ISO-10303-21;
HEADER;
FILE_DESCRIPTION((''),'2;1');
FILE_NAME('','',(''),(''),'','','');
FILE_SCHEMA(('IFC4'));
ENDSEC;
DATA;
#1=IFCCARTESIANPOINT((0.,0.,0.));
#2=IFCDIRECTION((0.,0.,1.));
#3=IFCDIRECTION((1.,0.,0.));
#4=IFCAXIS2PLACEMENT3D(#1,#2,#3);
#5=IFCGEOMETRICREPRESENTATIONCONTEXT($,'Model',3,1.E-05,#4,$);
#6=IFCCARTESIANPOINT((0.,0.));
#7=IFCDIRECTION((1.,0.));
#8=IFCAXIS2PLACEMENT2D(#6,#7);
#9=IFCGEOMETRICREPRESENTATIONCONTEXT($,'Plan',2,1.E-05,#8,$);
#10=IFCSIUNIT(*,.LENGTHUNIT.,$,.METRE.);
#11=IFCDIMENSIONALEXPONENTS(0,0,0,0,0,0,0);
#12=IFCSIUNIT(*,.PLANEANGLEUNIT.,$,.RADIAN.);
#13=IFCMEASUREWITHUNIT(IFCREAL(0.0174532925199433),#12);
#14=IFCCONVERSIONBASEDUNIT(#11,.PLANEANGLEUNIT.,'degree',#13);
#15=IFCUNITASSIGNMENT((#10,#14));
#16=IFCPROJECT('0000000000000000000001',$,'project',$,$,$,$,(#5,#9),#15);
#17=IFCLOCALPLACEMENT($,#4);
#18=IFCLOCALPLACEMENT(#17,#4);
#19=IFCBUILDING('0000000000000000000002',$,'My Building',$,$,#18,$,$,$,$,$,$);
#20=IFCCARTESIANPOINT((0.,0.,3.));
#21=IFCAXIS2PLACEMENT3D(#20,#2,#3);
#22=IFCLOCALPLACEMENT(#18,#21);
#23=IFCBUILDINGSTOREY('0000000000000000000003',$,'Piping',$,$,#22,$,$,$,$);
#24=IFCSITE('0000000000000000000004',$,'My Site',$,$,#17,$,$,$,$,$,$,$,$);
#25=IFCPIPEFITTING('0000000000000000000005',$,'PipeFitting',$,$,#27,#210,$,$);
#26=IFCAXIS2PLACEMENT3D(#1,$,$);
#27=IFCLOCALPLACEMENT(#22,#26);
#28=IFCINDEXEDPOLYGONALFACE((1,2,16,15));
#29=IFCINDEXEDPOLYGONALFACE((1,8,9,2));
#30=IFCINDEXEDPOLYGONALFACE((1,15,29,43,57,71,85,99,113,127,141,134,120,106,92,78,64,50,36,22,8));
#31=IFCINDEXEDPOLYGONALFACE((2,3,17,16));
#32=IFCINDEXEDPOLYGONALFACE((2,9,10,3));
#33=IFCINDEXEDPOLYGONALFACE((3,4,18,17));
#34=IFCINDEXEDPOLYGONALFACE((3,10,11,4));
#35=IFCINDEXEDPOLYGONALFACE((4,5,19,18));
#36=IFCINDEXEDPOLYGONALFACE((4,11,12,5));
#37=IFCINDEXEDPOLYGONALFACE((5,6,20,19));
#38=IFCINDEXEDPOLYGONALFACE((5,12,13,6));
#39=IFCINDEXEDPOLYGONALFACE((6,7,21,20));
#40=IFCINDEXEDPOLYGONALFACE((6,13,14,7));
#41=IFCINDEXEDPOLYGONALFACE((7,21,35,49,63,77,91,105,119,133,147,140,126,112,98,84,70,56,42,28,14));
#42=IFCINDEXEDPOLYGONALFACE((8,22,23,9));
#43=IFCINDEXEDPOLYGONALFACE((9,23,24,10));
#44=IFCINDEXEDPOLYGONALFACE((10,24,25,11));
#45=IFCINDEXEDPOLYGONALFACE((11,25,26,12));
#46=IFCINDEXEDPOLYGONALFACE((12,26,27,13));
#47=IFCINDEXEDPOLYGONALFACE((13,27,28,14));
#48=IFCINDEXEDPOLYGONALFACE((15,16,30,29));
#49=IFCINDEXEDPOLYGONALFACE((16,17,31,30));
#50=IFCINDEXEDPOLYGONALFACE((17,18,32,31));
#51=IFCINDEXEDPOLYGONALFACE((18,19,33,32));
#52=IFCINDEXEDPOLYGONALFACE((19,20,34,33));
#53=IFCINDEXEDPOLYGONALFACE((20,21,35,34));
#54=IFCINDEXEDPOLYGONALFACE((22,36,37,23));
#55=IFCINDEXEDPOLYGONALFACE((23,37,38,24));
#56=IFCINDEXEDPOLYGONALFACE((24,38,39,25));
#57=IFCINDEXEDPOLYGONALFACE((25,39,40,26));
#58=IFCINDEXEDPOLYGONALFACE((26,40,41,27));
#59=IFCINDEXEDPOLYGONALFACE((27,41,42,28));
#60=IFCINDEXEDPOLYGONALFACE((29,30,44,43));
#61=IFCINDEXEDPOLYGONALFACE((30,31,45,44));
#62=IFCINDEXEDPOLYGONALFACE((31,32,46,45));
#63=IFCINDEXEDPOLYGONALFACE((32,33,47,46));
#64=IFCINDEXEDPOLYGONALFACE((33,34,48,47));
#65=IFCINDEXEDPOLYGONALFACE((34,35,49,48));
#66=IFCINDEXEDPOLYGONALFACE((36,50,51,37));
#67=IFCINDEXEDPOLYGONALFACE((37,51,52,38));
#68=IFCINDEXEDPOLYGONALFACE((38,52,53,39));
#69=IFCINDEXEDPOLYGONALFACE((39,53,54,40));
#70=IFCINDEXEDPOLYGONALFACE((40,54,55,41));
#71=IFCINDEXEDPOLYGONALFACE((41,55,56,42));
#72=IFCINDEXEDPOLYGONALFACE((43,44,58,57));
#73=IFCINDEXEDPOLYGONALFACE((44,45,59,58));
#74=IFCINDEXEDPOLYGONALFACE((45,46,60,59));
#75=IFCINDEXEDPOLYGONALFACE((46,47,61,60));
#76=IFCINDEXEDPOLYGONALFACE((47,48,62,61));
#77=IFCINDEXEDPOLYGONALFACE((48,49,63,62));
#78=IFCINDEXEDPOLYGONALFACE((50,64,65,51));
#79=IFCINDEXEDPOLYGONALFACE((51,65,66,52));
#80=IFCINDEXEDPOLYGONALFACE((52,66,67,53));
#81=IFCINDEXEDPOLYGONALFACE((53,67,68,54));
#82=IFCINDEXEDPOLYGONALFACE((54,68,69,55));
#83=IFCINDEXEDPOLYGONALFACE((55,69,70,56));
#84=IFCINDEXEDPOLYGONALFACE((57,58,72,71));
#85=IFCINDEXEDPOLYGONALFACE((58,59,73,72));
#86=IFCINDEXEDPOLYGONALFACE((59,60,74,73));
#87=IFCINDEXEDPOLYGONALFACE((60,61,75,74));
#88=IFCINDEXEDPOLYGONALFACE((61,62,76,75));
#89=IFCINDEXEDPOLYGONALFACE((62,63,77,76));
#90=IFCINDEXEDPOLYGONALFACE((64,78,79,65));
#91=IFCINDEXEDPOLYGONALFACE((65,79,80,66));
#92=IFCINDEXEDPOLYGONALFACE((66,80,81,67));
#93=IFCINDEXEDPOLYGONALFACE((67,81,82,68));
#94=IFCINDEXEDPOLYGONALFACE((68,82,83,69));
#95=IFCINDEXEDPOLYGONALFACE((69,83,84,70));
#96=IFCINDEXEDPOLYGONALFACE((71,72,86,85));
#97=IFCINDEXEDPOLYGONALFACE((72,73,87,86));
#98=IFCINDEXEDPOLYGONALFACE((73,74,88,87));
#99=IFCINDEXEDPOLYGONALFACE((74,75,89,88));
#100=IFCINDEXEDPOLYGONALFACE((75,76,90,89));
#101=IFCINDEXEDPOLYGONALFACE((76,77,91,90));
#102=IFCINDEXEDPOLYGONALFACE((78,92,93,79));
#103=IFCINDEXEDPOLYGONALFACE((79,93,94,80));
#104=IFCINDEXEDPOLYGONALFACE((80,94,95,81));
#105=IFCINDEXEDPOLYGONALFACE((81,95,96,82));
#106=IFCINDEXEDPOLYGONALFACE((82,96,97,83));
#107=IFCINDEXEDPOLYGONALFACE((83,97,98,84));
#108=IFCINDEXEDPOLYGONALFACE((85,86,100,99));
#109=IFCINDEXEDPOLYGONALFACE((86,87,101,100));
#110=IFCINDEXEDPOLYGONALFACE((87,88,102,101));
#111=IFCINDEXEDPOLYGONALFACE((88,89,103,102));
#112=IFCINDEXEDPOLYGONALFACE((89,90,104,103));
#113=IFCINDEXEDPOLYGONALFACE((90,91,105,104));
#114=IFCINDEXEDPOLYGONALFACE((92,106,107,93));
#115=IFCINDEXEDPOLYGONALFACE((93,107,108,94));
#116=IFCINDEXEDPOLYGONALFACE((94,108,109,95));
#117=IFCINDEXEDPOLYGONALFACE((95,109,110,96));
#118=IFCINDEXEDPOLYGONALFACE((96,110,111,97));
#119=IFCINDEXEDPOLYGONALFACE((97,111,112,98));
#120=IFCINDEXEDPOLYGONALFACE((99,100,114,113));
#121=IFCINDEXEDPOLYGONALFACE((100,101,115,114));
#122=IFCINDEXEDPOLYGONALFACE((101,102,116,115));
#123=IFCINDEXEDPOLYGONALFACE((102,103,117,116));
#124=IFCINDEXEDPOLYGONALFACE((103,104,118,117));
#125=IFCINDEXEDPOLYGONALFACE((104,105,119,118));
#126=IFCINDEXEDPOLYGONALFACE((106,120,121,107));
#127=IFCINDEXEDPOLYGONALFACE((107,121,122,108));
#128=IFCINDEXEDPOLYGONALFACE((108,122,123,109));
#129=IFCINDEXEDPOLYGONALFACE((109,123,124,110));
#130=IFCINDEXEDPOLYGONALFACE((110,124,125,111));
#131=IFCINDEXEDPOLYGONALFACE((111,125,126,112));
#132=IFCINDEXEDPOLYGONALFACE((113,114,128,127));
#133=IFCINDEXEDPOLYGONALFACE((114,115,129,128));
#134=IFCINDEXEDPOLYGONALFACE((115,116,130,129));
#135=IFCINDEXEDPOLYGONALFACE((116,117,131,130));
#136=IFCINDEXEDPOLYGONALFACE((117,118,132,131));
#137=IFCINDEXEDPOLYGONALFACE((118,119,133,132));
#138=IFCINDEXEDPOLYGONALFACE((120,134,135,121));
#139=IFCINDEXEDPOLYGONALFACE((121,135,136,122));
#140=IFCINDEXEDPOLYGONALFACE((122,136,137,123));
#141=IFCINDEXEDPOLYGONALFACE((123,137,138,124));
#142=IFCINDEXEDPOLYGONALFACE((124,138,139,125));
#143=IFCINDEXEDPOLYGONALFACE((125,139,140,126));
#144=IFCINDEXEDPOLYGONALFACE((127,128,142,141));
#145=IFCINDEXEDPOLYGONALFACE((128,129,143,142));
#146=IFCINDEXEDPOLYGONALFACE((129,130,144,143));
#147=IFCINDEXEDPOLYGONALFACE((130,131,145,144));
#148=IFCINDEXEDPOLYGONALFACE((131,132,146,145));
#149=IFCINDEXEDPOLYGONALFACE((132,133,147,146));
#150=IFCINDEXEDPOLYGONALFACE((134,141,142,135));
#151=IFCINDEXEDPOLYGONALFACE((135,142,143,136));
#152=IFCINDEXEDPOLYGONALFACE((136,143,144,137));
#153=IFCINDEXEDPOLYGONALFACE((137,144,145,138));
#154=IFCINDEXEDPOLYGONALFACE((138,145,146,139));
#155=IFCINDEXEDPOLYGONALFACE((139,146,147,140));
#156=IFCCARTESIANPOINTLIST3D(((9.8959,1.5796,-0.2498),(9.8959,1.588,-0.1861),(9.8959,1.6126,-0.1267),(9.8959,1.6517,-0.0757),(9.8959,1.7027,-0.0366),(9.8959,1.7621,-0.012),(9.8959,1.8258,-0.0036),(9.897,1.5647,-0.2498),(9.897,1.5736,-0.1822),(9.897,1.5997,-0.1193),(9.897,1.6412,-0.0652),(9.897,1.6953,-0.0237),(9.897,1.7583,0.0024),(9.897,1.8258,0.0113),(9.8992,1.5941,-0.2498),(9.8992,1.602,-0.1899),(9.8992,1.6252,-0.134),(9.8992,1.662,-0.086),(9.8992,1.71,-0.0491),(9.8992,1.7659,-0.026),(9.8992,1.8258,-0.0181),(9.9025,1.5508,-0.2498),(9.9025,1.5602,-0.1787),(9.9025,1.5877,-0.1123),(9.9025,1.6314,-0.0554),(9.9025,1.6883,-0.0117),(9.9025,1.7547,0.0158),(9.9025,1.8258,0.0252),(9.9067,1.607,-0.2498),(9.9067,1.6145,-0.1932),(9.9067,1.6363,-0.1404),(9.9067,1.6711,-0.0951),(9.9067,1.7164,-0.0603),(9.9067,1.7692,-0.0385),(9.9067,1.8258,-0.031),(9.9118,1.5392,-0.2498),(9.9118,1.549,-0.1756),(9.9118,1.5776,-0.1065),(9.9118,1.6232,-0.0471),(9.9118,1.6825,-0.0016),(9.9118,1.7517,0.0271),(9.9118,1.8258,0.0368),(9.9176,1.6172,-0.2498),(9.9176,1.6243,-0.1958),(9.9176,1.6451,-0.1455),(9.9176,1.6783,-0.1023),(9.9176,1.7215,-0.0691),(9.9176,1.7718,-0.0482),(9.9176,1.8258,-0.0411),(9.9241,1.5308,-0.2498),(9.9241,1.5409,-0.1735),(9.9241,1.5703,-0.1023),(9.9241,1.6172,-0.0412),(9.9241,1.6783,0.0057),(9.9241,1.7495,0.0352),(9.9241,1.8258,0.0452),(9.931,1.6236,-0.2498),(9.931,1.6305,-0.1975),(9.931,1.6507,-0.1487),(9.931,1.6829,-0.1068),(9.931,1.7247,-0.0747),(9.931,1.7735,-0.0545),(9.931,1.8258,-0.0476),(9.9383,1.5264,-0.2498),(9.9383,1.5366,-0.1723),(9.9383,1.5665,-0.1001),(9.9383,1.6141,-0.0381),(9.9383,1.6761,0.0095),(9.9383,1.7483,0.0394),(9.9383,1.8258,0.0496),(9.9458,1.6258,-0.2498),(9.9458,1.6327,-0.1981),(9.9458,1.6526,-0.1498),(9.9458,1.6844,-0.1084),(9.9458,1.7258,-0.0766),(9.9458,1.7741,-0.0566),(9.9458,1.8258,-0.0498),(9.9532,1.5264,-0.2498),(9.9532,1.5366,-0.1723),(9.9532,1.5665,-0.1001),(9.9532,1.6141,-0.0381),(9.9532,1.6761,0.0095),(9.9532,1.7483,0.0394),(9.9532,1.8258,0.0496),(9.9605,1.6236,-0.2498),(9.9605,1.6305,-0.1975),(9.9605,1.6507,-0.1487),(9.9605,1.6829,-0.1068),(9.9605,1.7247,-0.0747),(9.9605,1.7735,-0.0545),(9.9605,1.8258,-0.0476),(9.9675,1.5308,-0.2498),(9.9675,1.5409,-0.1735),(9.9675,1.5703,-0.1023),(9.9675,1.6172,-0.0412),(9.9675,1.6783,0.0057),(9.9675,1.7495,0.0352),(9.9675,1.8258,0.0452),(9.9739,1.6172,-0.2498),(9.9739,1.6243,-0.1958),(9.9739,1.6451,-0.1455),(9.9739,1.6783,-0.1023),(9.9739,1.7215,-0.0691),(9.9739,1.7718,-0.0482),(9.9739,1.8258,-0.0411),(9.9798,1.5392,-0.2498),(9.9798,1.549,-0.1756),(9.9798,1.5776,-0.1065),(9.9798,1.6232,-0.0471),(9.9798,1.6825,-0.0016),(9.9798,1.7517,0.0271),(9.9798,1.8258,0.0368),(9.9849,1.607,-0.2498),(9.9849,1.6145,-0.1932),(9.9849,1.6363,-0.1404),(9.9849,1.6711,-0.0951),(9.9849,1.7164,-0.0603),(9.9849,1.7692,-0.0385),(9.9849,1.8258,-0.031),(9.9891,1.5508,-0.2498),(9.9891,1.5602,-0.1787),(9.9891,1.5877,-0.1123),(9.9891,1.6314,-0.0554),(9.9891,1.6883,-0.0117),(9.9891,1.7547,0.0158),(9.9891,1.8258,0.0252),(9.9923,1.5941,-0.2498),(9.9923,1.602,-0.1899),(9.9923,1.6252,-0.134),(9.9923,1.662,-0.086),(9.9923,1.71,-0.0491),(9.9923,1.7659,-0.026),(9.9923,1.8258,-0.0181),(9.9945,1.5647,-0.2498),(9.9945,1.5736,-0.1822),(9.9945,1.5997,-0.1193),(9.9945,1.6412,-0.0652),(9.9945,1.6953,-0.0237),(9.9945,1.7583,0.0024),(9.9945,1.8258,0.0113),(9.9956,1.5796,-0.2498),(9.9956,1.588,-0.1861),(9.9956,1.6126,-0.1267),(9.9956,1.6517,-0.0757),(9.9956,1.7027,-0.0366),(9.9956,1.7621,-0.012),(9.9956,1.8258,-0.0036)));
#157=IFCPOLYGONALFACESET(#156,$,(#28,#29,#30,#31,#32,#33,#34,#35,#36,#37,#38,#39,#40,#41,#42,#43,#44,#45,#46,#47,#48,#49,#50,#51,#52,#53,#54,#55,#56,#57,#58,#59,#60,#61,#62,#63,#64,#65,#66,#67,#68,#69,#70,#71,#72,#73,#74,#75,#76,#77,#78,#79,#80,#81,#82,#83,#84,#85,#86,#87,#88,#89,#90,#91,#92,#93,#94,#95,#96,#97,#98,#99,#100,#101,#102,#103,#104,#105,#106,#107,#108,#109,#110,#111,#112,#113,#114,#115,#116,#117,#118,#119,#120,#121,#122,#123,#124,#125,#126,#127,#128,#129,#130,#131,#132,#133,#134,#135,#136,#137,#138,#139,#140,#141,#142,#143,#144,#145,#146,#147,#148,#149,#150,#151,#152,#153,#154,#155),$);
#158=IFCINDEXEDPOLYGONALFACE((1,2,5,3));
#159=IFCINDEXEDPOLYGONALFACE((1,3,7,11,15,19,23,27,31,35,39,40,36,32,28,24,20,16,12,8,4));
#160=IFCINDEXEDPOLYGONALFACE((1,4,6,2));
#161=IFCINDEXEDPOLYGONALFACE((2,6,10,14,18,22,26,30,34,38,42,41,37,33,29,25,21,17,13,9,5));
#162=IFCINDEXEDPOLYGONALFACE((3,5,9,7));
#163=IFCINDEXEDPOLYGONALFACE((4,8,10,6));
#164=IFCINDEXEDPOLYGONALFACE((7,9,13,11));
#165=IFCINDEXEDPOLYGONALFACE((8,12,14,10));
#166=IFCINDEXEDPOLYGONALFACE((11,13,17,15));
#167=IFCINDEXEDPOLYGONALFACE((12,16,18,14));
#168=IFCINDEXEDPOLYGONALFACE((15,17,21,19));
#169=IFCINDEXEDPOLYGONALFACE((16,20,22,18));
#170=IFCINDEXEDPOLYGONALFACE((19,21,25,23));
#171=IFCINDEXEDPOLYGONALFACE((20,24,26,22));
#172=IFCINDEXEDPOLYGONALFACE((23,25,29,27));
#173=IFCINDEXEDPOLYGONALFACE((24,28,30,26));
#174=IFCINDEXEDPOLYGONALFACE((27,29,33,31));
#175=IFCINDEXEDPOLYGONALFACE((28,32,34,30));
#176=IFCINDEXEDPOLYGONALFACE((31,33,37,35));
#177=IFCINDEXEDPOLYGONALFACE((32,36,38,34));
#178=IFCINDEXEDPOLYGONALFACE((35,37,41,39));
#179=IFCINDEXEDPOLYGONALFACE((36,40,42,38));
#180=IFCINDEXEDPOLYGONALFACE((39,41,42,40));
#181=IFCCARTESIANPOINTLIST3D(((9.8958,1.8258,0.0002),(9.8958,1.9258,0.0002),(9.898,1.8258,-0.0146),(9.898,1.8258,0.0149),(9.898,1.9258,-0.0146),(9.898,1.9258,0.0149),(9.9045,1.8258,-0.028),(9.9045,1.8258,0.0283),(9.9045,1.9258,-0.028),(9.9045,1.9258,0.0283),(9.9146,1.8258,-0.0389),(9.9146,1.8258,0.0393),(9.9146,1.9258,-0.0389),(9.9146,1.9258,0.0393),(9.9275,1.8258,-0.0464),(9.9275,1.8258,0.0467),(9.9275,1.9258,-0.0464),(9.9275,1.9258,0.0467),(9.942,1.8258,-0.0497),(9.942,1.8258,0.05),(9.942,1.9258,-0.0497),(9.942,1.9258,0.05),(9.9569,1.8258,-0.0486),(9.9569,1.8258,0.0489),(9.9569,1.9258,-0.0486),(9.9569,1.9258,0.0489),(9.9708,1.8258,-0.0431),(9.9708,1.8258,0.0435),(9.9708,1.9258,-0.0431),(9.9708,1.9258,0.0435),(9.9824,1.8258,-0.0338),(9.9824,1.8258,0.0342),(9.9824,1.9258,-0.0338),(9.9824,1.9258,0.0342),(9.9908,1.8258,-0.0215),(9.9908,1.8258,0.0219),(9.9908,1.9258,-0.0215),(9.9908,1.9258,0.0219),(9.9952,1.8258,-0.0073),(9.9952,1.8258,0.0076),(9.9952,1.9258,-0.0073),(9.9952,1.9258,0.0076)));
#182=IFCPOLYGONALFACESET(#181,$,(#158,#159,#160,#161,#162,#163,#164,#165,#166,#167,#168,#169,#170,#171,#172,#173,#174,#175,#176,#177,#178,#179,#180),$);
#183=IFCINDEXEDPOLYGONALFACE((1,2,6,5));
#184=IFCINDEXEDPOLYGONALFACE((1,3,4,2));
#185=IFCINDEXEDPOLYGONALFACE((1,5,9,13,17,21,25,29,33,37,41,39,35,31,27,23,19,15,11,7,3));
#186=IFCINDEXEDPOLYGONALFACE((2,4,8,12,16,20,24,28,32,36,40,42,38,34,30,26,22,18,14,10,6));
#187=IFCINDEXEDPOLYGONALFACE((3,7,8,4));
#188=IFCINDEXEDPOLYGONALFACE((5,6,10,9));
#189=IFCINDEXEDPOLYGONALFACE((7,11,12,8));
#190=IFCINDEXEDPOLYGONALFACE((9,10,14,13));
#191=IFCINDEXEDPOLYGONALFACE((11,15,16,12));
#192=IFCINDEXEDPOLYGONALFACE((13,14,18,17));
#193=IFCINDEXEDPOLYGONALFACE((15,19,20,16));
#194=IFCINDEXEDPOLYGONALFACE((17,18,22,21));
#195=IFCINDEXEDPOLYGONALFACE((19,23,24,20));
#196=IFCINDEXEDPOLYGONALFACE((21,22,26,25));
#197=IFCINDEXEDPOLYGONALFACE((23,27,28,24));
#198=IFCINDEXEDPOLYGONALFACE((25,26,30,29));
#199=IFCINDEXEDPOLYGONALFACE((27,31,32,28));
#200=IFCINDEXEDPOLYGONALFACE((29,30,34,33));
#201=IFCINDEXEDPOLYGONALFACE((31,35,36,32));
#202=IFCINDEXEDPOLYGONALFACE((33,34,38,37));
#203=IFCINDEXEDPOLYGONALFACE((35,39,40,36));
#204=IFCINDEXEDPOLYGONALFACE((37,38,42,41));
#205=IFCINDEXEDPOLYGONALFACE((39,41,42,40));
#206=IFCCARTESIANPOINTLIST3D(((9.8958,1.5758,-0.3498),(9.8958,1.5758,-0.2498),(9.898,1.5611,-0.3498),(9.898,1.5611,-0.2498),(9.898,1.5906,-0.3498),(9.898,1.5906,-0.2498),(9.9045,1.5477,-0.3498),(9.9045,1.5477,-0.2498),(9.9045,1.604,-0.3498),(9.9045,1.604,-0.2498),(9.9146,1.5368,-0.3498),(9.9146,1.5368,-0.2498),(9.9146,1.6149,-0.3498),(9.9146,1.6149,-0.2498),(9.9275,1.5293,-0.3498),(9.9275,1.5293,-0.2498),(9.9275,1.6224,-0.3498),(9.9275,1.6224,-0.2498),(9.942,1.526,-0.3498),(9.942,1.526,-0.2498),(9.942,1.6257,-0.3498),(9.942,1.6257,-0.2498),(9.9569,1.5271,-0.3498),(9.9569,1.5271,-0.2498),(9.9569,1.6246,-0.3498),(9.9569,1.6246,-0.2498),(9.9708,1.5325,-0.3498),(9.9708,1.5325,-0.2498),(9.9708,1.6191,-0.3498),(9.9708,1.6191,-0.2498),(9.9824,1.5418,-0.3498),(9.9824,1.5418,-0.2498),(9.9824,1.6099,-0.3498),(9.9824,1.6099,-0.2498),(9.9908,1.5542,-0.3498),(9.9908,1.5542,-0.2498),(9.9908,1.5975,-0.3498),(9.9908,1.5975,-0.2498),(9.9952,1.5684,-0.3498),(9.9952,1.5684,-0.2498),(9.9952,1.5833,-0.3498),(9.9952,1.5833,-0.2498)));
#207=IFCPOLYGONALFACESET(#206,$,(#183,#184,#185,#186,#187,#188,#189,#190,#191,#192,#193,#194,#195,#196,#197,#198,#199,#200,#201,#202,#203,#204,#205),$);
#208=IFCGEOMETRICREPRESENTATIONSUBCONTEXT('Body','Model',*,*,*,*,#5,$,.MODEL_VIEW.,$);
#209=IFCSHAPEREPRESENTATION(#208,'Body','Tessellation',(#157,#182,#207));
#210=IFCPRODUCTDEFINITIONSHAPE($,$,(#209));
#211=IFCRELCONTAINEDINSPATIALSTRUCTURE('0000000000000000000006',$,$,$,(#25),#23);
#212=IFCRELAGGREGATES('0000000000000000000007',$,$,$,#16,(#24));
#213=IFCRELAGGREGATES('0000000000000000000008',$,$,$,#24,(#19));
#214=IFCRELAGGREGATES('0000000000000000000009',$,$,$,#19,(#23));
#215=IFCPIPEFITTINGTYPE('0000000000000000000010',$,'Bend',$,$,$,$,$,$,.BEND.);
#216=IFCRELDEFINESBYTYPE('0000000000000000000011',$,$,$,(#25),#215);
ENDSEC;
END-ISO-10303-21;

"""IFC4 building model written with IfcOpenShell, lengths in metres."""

from ifc_helpers import new_model, entity, si_unit, converted_unit, frame, origin_with_axes, origin_2d_with_axis, place, context, subcontext, project, spatial, circle, extrude, source, transform, mapped, type_object, type_shapes, element, save


model = new_model("IFC4")

# Units and contexts
model_context = context("Model", 3, precision=1e-05, world=origin_with_axes())
plan_context = context("Plan", 2, precision=1e-05, world=origin_2d_with_axis())
body_context = subcontext(model_context, "Body", "Model", "MODEL_VIEW")
ifc_project = project(units=[si_unit("LENGTHUNIT", "METRE"), converted_unit("PLANEANGLEUNIT", "degree", entity("IfcReal", 0.0174532925199433), si_unit("PLANEANGLEUNIT", "RADIAN"), dimensions=[0, 0, 0, 0, 0, 0, 0])], contexts=[model_context, plan_context])

# Site, building, storey
site_placement = place(None, origin_with_axes())
site = spatial("IfcSite", under=ifc_project, at=site_placement, Name="My Site")
building_placement = place(site_placement, origin_with_axes())
building = spatial("IfcBuilding", under=site, at=building_placement, Name="My Building")
storey_placement = place(building_placement, frame((0.0, 0.0, 3.0), z_axis=(0.0, 0.0, 1.0), x_axis=(1.0, 0.0, 0.0)))
storey = spatial("IfcBuildingStorey", under=building, at=storey_placement, Name="Piping")

# Pipe fitting
pipe_fitting_type = type_object("IfcPipeFittingType", Name="Bend", PredefinedType="BEND")
shared_shape = source(origin_with_axes(), body_context, "Body", "SolidModel", [
    entity("IfcSweptDiskSolid", entity("IfcIndexedPolyCurve", entity("IfcCartesianPointList3D", [[0.0, 0.0, -0.1], [0.0, -0.0732, -0.2768], [0.0, -0.25, -0.35]]), [entity("IfcArcIndex", [1, 2, 3])]), 0.05),
    extrude(circle(Radius=0.05), origin_with_axes(), (0.0, 0.0, -1.0), 0.1),
    extrude(circle(Radius=0.05), frame((0.0, -0.25, -0.35), z_axis=(0.0, -1.0, 0.0), x_axis=(1.0, 0.0, 0.0)), (0.0, 0.0, 1.0), 0.1),
])
type_shapes(pipe_fitting_type, [shared_shape])
for number, where, z_axis, x_axis, name in (
    (1, (9.9458, 1.9258, 0.0002), (0.0, 1.0, 0.0), (-1.0, 0.0, 0.0), "PipeFitting"),
):
    element("IfcPipeFitting", number, at=place(storey_placement, frame(where, z_axis=z_axis, x_axis=x_axis)), inside=storey, type_object=pipe_fitting_type, Name=name, context=body_context, shape_type="MappedRepresentation", body=[
        mapped(shared_shape, transform((0.0, 0.0, 0.0), x_axis=(1.0, 0.0, 0.0), y_axis=(0.0, 1.0, 0.0), z_axis=(0.0, 0.0, 1.0), scale=1.0)),
    ])

save(model, "model.ifc")
